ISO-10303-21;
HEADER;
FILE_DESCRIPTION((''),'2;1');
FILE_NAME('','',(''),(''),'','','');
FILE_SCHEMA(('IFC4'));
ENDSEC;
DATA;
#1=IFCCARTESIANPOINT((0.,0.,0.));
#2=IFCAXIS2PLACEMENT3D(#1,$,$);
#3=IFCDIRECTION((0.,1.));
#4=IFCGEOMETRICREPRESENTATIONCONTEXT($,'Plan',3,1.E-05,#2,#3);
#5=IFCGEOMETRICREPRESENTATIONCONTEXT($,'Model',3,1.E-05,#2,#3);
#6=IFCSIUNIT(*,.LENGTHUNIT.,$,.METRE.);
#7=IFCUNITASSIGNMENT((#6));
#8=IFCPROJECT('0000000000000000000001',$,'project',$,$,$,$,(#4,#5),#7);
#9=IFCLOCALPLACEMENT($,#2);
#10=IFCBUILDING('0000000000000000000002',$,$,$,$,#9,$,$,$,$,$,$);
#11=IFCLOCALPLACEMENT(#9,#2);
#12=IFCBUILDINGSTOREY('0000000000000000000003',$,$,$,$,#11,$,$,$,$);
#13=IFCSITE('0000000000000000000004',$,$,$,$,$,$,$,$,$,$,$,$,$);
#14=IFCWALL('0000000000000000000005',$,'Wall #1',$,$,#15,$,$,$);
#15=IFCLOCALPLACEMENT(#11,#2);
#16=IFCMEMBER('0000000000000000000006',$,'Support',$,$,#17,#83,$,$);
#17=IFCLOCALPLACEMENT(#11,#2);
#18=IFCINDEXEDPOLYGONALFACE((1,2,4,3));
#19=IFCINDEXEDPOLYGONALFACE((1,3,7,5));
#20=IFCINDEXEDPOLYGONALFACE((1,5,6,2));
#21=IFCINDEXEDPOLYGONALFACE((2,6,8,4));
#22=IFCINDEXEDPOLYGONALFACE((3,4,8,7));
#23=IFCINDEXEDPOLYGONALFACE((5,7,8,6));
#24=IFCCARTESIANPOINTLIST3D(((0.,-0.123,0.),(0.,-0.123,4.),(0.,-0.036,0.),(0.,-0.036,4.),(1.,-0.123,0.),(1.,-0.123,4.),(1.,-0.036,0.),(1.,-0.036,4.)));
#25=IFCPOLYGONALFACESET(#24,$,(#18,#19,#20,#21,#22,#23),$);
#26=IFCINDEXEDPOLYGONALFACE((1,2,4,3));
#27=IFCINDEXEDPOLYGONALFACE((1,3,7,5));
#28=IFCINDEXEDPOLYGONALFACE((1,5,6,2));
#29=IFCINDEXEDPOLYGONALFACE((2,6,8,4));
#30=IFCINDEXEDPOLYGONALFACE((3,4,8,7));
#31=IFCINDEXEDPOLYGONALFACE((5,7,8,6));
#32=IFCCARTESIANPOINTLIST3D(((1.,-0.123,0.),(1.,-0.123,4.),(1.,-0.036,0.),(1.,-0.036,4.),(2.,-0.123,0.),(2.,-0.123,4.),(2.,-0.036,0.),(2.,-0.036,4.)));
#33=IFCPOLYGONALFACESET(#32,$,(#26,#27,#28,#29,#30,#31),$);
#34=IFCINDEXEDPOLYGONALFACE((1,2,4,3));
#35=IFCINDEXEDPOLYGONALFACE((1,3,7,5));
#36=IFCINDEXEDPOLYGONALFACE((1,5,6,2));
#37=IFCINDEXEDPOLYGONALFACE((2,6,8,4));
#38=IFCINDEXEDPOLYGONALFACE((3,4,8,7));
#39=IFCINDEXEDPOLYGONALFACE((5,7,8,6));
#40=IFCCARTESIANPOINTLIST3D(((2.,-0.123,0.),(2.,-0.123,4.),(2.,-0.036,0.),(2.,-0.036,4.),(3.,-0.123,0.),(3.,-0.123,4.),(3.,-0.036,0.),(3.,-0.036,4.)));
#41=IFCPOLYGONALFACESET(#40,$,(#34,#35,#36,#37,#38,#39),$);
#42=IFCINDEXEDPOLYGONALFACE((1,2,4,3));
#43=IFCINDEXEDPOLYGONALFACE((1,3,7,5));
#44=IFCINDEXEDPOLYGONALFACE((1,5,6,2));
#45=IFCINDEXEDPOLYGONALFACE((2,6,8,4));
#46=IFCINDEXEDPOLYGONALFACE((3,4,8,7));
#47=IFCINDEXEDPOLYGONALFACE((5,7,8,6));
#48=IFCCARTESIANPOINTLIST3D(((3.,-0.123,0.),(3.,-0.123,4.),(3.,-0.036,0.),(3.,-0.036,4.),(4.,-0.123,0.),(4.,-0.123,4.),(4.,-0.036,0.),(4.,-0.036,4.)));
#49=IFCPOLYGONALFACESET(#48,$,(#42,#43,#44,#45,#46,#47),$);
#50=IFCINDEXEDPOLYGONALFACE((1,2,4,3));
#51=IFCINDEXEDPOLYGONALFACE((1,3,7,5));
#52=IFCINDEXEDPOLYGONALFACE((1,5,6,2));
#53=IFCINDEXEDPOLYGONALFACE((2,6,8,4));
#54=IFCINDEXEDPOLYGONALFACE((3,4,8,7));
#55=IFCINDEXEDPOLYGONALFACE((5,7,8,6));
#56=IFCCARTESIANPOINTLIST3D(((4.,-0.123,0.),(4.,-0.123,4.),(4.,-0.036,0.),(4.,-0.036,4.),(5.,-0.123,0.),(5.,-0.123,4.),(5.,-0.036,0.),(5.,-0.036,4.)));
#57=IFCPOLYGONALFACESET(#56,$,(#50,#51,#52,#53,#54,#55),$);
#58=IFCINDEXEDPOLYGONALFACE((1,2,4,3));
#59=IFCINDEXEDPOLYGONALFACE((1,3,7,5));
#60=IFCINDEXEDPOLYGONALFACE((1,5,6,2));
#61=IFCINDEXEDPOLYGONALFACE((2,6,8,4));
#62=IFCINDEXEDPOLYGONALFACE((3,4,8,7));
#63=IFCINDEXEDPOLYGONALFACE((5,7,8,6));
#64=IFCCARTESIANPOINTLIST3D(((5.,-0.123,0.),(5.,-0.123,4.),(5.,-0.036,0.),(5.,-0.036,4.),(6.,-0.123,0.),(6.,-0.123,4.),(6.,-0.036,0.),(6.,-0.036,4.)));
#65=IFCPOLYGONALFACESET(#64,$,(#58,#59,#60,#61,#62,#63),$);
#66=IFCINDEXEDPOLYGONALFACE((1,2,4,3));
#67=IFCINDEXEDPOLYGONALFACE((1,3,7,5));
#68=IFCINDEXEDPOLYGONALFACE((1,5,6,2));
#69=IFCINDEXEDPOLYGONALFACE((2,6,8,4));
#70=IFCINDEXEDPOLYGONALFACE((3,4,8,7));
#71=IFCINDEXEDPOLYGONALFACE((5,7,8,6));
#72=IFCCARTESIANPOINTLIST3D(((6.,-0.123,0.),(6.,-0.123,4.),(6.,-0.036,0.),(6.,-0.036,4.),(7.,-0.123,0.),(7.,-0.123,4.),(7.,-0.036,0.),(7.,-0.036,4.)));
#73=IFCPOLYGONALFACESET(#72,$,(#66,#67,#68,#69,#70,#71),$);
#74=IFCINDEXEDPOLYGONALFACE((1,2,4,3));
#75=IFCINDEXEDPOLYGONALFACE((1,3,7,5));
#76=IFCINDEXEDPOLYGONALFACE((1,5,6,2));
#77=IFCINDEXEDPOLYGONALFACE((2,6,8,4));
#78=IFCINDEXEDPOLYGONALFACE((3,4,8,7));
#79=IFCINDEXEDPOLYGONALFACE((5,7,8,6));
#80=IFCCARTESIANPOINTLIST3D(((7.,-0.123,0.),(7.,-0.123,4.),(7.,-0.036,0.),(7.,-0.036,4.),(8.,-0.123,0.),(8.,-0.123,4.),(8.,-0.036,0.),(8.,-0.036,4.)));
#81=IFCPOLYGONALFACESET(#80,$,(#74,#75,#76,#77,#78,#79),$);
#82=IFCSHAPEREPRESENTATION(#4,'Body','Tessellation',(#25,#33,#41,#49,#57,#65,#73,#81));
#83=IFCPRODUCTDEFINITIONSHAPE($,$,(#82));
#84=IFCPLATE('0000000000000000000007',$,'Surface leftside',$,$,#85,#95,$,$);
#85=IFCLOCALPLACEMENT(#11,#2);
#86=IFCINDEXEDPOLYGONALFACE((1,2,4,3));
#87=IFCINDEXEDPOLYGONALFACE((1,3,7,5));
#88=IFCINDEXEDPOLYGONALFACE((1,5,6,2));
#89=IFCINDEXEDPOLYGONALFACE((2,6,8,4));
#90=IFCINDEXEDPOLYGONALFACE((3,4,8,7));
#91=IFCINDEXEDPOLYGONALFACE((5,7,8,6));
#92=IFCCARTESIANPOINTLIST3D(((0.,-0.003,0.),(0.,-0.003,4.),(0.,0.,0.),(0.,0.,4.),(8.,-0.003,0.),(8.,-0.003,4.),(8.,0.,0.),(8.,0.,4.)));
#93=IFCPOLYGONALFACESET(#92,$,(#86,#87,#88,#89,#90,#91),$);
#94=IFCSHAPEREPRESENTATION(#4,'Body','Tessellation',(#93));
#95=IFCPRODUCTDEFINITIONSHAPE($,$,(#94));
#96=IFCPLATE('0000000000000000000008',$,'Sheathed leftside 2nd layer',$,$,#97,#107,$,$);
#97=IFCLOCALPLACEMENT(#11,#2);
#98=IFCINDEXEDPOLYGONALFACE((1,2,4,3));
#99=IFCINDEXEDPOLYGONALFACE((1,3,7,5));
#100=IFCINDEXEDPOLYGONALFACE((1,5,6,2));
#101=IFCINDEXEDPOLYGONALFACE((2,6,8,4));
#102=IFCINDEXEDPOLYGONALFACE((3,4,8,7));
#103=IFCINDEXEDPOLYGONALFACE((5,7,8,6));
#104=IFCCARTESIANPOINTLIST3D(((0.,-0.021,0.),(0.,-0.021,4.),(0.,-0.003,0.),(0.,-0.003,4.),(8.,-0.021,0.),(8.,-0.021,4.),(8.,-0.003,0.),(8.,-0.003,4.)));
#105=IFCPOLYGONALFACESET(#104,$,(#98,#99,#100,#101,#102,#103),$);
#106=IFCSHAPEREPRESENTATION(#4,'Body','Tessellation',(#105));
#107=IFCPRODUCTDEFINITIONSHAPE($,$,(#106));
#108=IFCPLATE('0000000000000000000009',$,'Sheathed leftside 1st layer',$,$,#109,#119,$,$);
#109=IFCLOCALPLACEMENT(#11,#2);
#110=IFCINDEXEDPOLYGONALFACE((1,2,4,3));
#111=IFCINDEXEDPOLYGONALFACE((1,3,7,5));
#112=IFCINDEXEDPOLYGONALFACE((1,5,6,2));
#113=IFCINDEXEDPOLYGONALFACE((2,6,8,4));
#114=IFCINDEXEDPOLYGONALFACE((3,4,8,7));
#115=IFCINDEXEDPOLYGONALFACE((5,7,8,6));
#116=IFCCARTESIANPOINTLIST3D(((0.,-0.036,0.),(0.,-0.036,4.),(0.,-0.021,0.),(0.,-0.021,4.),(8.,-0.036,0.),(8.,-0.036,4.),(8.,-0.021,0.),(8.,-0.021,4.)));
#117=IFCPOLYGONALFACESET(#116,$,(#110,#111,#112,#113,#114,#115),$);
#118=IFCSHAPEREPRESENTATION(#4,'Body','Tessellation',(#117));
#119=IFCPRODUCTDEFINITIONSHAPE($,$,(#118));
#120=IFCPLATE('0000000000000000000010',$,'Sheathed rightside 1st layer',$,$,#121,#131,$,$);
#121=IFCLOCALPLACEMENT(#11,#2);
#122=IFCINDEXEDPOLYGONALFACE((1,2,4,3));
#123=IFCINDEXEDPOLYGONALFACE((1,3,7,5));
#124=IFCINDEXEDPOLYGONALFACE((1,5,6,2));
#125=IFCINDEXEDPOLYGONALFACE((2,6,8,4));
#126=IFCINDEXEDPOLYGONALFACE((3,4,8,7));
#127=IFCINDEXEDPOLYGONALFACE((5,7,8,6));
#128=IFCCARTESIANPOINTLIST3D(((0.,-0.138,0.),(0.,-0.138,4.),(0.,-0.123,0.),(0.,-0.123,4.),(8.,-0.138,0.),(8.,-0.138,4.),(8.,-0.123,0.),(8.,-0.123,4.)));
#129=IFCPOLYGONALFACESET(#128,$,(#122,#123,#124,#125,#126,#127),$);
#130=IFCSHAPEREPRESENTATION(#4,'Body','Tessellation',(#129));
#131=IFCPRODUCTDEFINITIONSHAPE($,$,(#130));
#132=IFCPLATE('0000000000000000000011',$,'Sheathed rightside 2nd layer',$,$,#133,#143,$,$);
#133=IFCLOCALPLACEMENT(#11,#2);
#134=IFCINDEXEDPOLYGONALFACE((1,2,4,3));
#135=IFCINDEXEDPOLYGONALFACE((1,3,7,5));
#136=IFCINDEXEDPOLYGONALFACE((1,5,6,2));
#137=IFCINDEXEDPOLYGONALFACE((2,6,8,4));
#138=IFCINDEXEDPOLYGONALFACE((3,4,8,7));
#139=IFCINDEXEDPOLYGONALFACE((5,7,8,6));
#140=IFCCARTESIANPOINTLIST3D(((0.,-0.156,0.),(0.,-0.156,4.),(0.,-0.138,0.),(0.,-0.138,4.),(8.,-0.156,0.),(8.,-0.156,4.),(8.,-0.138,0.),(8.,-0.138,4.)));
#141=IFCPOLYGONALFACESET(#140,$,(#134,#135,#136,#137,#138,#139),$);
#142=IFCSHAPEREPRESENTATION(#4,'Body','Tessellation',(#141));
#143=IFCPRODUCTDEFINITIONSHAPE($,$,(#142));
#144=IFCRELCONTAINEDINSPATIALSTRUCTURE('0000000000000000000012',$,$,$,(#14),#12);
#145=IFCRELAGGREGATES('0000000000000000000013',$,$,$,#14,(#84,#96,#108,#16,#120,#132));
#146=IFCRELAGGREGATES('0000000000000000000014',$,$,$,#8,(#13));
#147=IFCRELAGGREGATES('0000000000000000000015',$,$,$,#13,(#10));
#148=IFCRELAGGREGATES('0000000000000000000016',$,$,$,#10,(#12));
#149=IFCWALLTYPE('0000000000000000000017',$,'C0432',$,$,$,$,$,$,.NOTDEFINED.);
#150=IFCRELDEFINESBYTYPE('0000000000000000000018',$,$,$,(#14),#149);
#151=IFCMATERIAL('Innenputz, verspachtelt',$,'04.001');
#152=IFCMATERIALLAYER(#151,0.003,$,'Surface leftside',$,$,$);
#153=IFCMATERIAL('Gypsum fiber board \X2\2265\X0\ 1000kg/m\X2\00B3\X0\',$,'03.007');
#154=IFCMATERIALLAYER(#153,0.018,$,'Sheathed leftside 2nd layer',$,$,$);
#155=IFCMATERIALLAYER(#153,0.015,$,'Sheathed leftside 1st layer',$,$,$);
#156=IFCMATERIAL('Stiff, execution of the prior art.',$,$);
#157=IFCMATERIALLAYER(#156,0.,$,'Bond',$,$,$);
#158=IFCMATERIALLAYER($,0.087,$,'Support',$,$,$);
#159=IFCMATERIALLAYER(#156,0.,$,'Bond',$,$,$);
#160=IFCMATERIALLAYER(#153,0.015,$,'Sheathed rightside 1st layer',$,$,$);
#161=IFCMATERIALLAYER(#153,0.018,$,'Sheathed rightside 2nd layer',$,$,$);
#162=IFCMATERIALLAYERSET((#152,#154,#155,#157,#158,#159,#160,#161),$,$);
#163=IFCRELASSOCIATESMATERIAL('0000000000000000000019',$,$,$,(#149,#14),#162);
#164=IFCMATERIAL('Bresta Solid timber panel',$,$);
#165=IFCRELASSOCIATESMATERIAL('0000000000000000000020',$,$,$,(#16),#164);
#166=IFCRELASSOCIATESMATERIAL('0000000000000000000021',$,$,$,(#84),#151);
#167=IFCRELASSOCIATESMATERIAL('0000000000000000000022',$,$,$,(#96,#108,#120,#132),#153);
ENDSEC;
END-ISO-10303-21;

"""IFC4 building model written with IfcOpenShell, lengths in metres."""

from ifc_helpers import new_model, si_unit, direction, frame, frame_2d, origin, origin_with_axes, place, context, project, spatial, rectangle, extrude, material, layer, layer_set, type_object, element, aggregate, save


model = new_model("IFC4")

# Units and contexts
plan_context = context("Plan", 3, precision=1e-05, world=origin(), true_north=direction((0.0, 1.0)))
model_context = context("Model", 3, precision=1e-05, world=origin(), true_north=direction((0.0, 1.0)))
ifc_project = project(units=[si_unit("LENGTHUNIT", "METRE")], contexts=[plan_context, model_context])

# Site, building, storey
site = spatial("IfcSite", under=ifc_project)
building_placement = place(None, origin())
building = spatial("IfcBuilding", under=site, at=building_placement)
storey_placement = place(building_placement, origin())
storey = spatial("IfcBuildingStorey", under=building, at=storey_placement)

# Wall, member, plates
ifc_material_1 = material(Name="Innenputz, verspachtelt", Category="04.001")
ifc_layer_1 = layer(ifc_material_1, 0.003, Name="Surface leftside")
ifc_material_2 = material(Name="Gypsum fiber board ≥ 1000kg/m³", Category="03.007")
ifc_layer_2 = layer(ifc_material_2, 0.018, Name="Sheathed leftside 2nd layer")
ifc_layer_3 = layer(ifc_material_2, 0.015, Name="Sheathed leftside 1st layer")
ifc_material_3 = material(Name="Stiff, execution of the prior art.")
ifc_layer_4 = layer(ifc_material_3, 0.0, Name="Bond")
ifc_layer_5 = layer(None, 0.087, Name="Support")
ifc_layer_6 = layer(ifc_material_3, 0.0, Name="Bond")
ifc_layer_7 = layer(ifc_material_2, 0.015, Name="Sheathed rightside 1st layer")
ifc_layer_8 = layer(ifc_material_2, 0.018, Name="Sheathed rightside 2nd layer")
ifc_layer_set = layer_set([ifc_layer_1, ifc_layer_2, ifc_layer_3, ifc_layer_4, ifc_layer_5, ifc_layer_6, ifc_layer_7, ifc_layer_8])
wall_type = type_object("IfcWallType", Name="C0432", PredefinedType="NOTDEFINED", material=ifc_layer_set)
wall_placement = place(None, frame((0.0, 0.0, 0.0), z_axis=(0.0, -1.0, 0.0), x_axis=(1.0, 0.0, 0.0)))
wall = element("IfcWall", 1, at=wall_placement, inside=storey, type_object=wall_type, material=ifc_layer_set, Name="Wall #1")
ifc_material_4 = material(Name="Bresta Solid timber panel")
member_placement = place(wall_placement, origin())
member = element("IfcMember", 2, at=member_placement, material=ifc_material_4, Name="Support", context=plan_context, shape_type="SweptSolid", body=[
    extrude(rectangle(XDim=1.0, YDim=0.087, at=frame_2d((0.5, 0.0435), x_axis=(1.0, 0.0))), frame((0.0, 4.0, 0.036), z_axis=(0.0, -1.0, 0.0), x_axis=(1.0, 0.0, 0.0)), (0.0, 0.0, 1.0), 4.0),
    extrude(rectangle(XDim=1.0, YDim=0.087, at=frame_2d((0.5, 0.0435), x_axis=(1.0, 0.0))), frame((1.0, 4.0, 0.036), z_axis=(0.0, -1.0, 0.0), x_axis=(1.0, 0.0, 0.0)), (0.0, 0.0, 1.0), 4.0),
    extrude(rectangle(XDim=1.0, YDim=0.087, at=frame_2d((0.5, 0.0435), x_axis=(1.0, 0.0))), frame((2.0, 4.0, 0.036), z_axis=(0.0, -1.0, 0.0), x_axis=(1.0, 0.0, 0.0)), (0.0, 0.0, 1.0), 4.0),
    extrude(rectangle(XDim=1.0, YDim=0.087, at=frame_2d((0.5, 0.0435), x_axis=(1.0, 0.0))), frame((3.0, 4.0, 0.036), z_axis=(0.0, -1.0, 0.0), x_axis=(1.0, 0.0, 0.0)), (0.0, 0.0, 1.0), 4.0),
    extrude(rectangle(XDim=1.0, YDim=0.087, at=frame_2d((0.5, 0.0435), x_axis=(1.0, 0.0))), frame((4.0, 4.0, 0.036), z_axis=(0.0, -1.0, 0.0), x_axis=(1.0, 0.0, 0.0)), (0.0, 0.0, 1.0), 4.0),
    extrude(rectangle(XDim=1.0, YDim=0.087, at=frame_2d((0.5, 0.0435), x_axis=(1.0, 0.0))), frame((5.0, 4.0, 0.036), z_axis=(0.0, -1.0, 0.0), x_axis=(1.0, 0.0, 0.0)), (0.0, 0.0, 1.0), 4.0),
    extrude(rectangle(XDim=1.0, YDim=0.087, at=frame_2d((0.5, 0.0435), x_axis=(1.0, 0.0))), frame((6.0, 4.0, 0.036), z_axis=(0.0, -1.0, 0.0), x_axis=(1.0, 0.0, 0.0)), (0.0, 0.0, 1.0), 4.0),
    extrude(rectangle(XDim=1.0, YDim=0.087, at=frame_2d((0.5, 0.0435), x_axis=(1.0, 0.0))), frame((7.0, 4.0, 0.036), z_axis=(0.0, -1.0, 0.0), x_axis=(1.0, 0.0, 0.0)), (0.0, 0.0, 1.0), 4.0),
])
plate_1_placement = place(wall_placement, origin())
plate_1 = element("IfcPlate", 3, at=plate_1_placement, material=ifc_material_1, Name="Surface leftside", context=plan_context, shape_type="SweptSolid", body=[
    extrude(rectangle(XDim=8.0, YDim=4.0, at=frame_2d((4.0, 2.0), x_axis=(1.0, 0.0))), origin_with_axes(), (0.0, 0.0, 1.0), 0.003),
])
plate_2_placement = place(wall_placement, origin())
plate_2 = element("IfcPlate", 4, at=plate_2_placement, material=ifc_material_2, Name="Sheathed leftside 2nd layer", context=plan_context, shape_type="SweptSolid", body=[
    extrude(rectangle(XDim=8.0, YDim=4.0, at=frame_2d((4.0, 2.0), x_axis=(1.0, 0.0))), frame((0.0, 0.0, 0.003), z_axis=(0.0, 0.0, 1.0), x_axis=(1.0, 0.0, 0.0)), (0.0, 0.0, 1.0), 0.018),
])
plate_3_placement = place(wall_placement, origin())
plate_3 = element("IfcPlate", 5, at=plate_3_placement, material=ifc_material_2, Name="Sheathed leftside 1st layer", context=plan_context, shape_type="SweptSolid", body=[
    extrude(rectangle(XDim=8.0, YDim=4.0, at=frame_2d((4.0, 2.0), x_axis=(1.0, 0.0))), frame((0.0, 0.0, 0.021), z_axis=(0.0, 0.0, 1.0), x_axis=(1.0, 0.0, 0.0)), (0.0, 0.0, 1.0), 0.015),
])
plate_4_placement = place(wall_placement, origin())
plate_4 = element("IfcPlate", 6, at=plate_4_placement, material=ifc_material_2, Name="Sheathed rightside 1st layer", context=plan_context, shape_type="SweptSolid", body=[
    extrude(rectangle(XDim=8.0, YDim=4.0, at=frame_2d((4.0, 2.0), x_axis=(1.0, 0.0))), frame((0.0, 0.0, 0.123), z_axis=(0.0, 0.0, 1.0), x_axis=(1.0, 0.0, 0.0)), (0.0, 0.0, 1.0), 0.015),
])
plate_5_placement = place(wall_placement, origin())
plate_5 = element("IfcPlate", 7, at=plate_5_placement, material=ifc_material_2, Name="Sheathed rightside 2nd layer", context=plan_context, shape_type="SweptSolid", body=[
    extrude(rectangle(XDim=8.0, YDim=4.0, at=frame_2d((4.0, 2.0), x_axis=(1.0, 0.0))), frame((0.0, 0.0, 0.138), z_axis=(0.0, 0.0, 1.0), x_axis=(1.0, 0.0, 0.0)), (0.0, 0.0, 1.0), 0.018),
])
aggregate(wall, [plate_1, plate_2, plate_3, member, plate_4, plate_5])

save(model, "model.ifc")
